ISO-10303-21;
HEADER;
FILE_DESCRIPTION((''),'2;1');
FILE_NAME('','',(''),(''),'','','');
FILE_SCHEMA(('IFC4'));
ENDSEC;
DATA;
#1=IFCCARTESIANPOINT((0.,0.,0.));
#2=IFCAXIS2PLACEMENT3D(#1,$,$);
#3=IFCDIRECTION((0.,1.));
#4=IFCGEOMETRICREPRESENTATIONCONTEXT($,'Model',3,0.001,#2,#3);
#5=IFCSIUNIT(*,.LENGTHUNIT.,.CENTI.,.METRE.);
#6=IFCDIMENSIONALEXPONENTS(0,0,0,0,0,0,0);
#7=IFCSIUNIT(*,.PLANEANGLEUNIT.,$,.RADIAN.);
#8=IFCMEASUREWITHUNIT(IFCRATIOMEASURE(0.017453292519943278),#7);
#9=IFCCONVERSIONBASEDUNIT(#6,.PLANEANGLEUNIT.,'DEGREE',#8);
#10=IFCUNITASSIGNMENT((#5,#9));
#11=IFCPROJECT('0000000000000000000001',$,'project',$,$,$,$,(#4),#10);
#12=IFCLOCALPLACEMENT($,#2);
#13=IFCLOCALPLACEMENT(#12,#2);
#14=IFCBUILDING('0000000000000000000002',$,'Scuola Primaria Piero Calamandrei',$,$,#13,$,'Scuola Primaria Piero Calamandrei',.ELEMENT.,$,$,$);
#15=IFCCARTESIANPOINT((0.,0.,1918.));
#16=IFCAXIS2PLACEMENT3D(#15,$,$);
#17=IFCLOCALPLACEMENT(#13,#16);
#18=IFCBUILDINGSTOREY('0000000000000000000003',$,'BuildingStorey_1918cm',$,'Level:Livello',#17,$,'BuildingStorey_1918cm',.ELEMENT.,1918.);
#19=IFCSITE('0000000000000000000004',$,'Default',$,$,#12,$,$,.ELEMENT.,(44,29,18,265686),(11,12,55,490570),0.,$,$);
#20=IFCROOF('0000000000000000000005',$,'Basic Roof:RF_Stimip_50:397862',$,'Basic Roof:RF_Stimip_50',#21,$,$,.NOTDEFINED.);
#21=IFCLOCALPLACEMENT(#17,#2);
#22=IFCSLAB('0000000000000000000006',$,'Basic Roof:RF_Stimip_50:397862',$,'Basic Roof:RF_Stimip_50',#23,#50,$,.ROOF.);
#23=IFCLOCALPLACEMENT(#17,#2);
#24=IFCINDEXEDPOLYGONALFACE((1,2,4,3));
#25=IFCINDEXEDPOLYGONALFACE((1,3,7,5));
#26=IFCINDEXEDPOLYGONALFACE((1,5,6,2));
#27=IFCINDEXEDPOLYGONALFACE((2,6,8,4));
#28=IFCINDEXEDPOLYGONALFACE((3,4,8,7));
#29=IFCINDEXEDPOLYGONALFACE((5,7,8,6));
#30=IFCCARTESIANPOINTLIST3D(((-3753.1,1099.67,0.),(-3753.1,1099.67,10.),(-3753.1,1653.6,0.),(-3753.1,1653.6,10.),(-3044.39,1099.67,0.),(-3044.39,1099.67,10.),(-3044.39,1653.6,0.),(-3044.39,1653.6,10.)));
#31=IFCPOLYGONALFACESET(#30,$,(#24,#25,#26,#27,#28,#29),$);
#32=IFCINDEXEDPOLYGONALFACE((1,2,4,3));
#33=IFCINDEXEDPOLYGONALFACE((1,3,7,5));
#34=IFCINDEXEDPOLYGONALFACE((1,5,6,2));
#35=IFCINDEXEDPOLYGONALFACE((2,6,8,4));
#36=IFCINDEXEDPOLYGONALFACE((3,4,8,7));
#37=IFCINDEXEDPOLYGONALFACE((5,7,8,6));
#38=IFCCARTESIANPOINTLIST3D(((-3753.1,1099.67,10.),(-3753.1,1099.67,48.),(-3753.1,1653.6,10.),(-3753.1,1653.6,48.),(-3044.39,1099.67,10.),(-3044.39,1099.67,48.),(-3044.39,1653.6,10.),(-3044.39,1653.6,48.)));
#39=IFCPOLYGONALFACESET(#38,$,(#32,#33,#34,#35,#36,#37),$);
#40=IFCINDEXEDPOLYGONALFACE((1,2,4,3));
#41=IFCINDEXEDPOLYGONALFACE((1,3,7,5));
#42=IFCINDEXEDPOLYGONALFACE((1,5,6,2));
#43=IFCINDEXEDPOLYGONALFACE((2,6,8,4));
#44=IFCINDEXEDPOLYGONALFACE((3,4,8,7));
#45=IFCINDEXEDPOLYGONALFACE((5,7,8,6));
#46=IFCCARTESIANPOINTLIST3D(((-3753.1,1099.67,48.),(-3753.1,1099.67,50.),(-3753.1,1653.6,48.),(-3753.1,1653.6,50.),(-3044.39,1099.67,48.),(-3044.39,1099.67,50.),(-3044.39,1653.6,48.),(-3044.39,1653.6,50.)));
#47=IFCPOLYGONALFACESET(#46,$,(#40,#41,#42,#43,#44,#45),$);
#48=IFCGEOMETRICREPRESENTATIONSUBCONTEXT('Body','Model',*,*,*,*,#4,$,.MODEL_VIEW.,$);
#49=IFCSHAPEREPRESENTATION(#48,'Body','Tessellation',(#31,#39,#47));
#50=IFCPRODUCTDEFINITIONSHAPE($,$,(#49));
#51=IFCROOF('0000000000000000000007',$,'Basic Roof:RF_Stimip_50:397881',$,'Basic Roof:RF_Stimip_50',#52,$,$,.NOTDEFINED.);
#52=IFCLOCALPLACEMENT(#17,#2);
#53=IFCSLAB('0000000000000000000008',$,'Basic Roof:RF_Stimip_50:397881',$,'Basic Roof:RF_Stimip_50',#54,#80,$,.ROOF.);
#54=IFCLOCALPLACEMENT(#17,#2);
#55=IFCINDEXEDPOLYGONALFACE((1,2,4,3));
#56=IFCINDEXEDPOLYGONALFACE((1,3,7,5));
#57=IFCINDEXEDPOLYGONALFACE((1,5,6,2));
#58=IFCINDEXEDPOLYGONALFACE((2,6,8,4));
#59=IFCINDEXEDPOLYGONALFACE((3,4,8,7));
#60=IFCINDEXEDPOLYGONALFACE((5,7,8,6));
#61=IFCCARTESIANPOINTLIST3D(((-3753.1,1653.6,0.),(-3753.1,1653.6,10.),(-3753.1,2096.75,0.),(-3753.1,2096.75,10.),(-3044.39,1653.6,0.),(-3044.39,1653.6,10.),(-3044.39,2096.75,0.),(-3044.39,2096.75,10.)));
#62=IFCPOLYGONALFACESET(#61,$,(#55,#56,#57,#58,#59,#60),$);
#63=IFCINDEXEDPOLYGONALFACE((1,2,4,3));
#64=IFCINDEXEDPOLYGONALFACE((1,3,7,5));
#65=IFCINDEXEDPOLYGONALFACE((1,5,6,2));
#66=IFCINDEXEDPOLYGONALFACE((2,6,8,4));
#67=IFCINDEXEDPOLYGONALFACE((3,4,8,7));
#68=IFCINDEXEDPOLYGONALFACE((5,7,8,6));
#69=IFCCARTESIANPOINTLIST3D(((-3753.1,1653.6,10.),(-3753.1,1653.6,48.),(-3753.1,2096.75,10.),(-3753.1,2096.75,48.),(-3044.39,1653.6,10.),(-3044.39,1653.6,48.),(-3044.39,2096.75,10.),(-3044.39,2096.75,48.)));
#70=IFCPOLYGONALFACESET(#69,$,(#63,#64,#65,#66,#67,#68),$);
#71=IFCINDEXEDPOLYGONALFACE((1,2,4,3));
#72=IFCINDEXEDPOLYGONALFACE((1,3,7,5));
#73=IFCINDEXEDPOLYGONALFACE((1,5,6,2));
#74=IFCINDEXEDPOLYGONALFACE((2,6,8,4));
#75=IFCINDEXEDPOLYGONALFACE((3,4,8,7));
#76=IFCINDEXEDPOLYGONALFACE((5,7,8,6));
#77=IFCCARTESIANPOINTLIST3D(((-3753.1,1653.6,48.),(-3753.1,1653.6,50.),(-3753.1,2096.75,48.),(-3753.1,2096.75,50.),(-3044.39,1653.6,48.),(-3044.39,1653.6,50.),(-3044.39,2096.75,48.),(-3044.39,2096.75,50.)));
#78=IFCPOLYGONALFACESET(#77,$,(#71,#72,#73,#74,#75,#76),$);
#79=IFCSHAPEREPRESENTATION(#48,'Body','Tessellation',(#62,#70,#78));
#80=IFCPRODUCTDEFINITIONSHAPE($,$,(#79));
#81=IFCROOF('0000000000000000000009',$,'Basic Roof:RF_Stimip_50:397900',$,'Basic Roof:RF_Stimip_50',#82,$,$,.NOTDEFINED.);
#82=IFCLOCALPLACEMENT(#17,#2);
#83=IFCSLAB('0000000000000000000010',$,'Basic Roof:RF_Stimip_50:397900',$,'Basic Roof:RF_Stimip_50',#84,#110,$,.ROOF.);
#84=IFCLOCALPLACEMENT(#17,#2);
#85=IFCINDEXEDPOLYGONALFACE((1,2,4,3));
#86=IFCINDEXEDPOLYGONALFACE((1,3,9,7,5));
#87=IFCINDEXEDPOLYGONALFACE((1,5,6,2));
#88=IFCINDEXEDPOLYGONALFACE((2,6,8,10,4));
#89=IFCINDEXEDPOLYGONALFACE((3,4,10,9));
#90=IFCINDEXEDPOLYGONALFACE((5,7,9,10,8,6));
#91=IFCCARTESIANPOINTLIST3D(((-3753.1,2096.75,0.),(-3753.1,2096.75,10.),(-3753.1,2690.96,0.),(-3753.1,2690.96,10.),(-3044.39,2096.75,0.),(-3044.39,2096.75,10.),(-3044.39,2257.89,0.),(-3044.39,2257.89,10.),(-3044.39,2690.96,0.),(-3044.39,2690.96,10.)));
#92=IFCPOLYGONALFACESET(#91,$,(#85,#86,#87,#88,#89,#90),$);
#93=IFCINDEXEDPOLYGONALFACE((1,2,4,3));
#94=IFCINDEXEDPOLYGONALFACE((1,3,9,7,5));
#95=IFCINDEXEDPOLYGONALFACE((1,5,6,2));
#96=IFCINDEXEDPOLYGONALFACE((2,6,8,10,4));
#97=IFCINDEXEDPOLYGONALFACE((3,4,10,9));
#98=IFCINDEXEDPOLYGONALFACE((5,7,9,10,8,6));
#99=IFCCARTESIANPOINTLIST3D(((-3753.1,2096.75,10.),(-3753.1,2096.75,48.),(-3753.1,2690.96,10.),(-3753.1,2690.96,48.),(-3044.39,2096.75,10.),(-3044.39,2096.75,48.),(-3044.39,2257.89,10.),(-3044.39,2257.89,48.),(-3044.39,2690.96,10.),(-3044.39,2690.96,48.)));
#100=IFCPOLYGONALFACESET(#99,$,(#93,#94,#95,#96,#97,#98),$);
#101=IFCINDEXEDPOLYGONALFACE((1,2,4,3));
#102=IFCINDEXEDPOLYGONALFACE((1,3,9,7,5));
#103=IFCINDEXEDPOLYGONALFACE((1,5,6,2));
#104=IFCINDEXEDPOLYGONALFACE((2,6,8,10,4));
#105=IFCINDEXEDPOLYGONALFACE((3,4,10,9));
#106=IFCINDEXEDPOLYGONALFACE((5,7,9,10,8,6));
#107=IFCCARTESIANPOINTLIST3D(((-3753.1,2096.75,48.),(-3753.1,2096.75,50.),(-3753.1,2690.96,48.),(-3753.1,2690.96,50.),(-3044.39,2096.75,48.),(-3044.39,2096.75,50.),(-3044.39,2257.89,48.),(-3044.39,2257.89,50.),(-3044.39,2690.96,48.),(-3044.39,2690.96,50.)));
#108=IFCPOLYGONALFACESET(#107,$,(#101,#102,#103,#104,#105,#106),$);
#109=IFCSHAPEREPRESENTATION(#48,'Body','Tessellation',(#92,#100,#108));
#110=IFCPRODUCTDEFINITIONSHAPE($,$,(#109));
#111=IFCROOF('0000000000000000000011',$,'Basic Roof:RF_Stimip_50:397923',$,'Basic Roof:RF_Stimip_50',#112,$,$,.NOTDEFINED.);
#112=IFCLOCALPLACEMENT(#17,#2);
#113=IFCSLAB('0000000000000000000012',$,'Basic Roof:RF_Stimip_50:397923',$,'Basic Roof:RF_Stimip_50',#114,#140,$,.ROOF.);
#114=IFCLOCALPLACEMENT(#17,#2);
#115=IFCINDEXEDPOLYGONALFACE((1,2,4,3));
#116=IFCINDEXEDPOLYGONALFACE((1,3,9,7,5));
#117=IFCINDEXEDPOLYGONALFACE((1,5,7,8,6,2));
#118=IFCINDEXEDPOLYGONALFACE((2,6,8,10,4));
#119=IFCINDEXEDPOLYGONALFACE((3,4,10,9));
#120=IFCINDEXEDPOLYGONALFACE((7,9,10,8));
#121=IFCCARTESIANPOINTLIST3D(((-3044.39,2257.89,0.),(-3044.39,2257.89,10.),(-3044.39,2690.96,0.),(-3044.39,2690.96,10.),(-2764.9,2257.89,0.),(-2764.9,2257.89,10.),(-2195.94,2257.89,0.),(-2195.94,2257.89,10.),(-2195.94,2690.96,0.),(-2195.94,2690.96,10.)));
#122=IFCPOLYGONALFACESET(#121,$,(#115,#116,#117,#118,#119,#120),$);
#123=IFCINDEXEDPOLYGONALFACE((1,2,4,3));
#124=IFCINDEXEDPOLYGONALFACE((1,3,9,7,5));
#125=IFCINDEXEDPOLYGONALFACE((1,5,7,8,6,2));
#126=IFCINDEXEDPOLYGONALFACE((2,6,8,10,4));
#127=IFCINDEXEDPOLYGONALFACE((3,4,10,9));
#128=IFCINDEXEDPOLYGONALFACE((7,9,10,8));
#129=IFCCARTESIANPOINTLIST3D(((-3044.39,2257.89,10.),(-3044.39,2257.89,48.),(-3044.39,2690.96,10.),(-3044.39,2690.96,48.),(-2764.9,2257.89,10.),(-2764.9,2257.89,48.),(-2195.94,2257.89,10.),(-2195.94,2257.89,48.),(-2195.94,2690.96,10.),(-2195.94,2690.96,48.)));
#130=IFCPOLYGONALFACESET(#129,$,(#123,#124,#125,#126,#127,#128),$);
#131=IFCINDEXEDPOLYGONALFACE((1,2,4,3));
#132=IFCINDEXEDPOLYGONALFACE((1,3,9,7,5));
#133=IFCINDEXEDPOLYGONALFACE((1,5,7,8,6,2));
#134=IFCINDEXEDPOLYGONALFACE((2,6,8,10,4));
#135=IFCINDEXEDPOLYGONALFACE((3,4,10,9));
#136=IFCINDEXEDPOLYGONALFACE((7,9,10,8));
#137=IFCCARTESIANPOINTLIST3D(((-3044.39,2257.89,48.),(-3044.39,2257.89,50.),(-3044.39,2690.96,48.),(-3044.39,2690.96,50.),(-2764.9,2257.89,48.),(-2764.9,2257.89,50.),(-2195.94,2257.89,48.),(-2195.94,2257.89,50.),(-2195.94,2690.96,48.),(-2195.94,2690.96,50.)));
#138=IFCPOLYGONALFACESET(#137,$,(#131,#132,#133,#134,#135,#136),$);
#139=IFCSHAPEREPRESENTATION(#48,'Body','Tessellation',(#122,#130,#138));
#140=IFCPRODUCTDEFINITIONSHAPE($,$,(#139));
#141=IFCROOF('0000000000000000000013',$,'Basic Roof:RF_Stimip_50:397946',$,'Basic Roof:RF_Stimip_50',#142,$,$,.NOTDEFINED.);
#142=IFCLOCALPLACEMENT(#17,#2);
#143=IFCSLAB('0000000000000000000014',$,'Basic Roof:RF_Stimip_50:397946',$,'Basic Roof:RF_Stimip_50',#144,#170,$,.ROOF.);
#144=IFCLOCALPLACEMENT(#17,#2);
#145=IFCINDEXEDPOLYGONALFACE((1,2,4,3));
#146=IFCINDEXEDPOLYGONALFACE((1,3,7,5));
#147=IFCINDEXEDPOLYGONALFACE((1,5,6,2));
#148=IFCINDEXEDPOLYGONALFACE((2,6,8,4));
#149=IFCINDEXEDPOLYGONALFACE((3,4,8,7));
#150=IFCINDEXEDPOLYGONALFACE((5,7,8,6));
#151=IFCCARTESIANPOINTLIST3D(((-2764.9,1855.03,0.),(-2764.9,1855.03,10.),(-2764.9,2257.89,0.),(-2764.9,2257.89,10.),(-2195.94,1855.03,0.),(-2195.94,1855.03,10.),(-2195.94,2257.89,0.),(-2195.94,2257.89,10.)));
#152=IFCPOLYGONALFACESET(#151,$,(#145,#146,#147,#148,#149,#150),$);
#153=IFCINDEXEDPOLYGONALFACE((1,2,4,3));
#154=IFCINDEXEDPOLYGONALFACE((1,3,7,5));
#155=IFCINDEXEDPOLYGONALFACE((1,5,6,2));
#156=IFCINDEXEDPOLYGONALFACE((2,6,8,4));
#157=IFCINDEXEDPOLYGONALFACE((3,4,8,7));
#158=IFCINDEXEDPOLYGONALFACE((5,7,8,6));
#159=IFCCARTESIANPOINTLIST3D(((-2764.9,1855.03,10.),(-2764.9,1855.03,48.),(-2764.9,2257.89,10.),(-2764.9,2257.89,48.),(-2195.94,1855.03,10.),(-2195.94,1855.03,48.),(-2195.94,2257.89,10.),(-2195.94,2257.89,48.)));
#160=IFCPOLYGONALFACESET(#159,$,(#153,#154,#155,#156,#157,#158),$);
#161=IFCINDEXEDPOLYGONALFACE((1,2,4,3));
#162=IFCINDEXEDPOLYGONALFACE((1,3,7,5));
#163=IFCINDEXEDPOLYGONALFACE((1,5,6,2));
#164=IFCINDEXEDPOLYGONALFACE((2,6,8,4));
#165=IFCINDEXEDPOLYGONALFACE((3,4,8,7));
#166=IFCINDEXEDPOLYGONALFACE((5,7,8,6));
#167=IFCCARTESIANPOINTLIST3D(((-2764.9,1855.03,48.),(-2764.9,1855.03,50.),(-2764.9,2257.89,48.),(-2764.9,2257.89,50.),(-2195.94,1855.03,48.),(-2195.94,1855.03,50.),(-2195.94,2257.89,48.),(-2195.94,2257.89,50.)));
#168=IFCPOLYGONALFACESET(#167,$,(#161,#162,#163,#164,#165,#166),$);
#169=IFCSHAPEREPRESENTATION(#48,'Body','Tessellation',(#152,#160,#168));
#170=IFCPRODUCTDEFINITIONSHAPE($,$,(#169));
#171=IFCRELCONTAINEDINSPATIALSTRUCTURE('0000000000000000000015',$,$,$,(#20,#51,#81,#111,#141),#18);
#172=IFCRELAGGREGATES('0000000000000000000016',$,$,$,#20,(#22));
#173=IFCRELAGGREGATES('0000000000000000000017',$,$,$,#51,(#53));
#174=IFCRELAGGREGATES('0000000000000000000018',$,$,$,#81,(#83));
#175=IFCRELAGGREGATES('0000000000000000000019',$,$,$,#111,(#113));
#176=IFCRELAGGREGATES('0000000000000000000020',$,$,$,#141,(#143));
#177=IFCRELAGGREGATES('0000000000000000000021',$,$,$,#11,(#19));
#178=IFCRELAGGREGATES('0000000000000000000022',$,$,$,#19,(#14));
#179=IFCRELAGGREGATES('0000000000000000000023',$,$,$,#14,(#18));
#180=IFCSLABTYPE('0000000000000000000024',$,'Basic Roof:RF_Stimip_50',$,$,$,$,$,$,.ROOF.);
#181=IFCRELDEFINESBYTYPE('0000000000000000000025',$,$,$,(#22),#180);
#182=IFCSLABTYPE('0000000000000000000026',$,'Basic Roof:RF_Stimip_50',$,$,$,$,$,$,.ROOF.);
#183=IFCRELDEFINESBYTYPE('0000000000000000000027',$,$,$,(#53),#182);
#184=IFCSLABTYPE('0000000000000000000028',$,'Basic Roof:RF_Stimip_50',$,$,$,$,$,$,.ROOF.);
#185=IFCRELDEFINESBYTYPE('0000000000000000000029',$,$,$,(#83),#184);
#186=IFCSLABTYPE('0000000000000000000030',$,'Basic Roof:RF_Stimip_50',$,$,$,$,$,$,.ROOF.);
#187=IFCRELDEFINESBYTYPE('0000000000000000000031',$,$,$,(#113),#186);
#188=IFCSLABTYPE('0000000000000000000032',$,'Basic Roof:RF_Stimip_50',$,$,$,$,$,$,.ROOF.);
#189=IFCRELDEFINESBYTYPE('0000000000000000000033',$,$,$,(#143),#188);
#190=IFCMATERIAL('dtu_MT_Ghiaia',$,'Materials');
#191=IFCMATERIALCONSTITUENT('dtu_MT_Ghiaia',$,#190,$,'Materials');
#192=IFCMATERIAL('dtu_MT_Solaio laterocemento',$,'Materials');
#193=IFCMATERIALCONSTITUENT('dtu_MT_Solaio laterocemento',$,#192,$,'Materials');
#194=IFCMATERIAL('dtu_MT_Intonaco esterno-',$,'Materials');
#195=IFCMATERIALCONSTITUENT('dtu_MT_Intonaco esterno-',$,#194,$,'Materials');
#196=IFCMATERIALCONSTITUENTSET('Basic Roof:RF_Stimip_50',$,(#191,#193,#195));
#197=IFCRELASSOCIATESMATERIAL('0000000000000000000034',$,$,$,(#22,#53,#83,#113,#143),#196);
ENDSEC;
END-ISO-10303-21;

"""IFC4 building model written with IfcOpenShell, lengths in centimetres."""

from ifc_helpers import new_model, entity, si_unit, converted_unit, direction, frame, origin, place, context, subcontext, project, spatial, indexed_curve, outline, extrude, material, constituent, constituent_set, type_object, element, aggregate, save


model = new_model("IFC4")

# Units and contexts
model_context = context("Model", 3, precision=0.001, world=origin(), true_north=direction((0.0, 1.0)))
body_context = subcontext(model_context, "Body", "Model", "MODEL_VIEW")
ifc_project = project(units=[si_unit("LENGTHUNIT", "METRE", prefix="CENTI"), converted_unit("PLANEANGLEUNIT", "DEGREE", entity("IfcRatioMeasure", 0.017453292519943278), si_unit("PLANEANGLEUNIT", "RADIAN"), dimensions=[0, 0, 0, 0, 0, 0, 0])], contexts=[model_context])

# Site, building, storey
site_placement = place(None, origin())
site = spatial("IfcSite", under=ifc_project, at=site_placement, Name="Default", CompositionType="ELEMENT", RefLatitude=(44, 29, 18, 265686), RefLongitude=(11, 12, 55, 490570), RefElevation=0.0)
building_placement = place(site_placement, origin())
building = spatial("IfcBuilding", under=site, at=building_placement, Name="Scuola Primaria Piero Calamandrei", LongName="Scuola Primaria Piero Calamandrei", CompositionType="ELEMENT")
storey_placement = place(building_placement, frame((0.0, 0.0, 1918.0)))
storey = spatial("IfcBuildingStorey", under=building, at=storey_placement, Name="BuildingStorey_1918cm", ObjectType="Level:Livello", LongName="BuildingStorey_1918cm", CompositionType="ELEMENT", Elevation=1918.0)

# Roofs, slabs
ifc_material_1 = material(Name="dtu_MT_Ghiaia", Category="Materials")
ifc_constituent_1 = constituent(ifc_material_1, Name="dtu_MT_Ghiaia", Category="Materials")
ifc_material_2 = material(Name="dtu_MT_Solaio laterocemento", Category="Materials")
ifc_constituent_2 = constituent(ifc_material_2, Name="dtu_MT_Solaio laterocemento", Category="Materials")
ifc_material_3 = material(Name="dtu_MT_Intonaco esterno-", Category="Materials")
ifc_constituent_3 = constituent(ifc_material_3, Name="dtu_MT_Intonaco esterno-", Category="Materials")
ifc_constituent_set = constituent_set(constituents=[ifc_constituent_1, ifc_constituent_2, ifc_constituent_3], Name="Basic Roof:RF_Stimip_50")
roof_1_placement = place(storey_placement, frame((-3753.1, 1099.67, 0.0)))
roof_1 = element("IfcRoof", 1, at=roof_1_placement, inside=storey, Name="Basic Roof:RF_Stimip_50:397862", ObjectType="Basic Roof:RF_Stimip_50", PredefinedType="NOTDEFINED")
slab_type_1 = type_object("IfcSlabType", Name="Basic Roof:RF_Stimip_50", PredefinedType="ROOF")
slab_1_placement = place(roof_1_placement, origin())
slab_1 = element("IfcSlab", 2, at=slab_1_placement, type_object=slab_type_1, material=ifc_constituent_set, Name="Basic Roof:RF_Stimip_50:397862", ObjectType="Basic Roof:RF_Stimip_50", PredefinedType="ROOF", context=body_context, shape_type="SweptSolid", body=[
    extrude(outline(indexed_curve([(-354.35, 276.96), (-354.35, -276.96), (354.35, -276.96), (354.35, 276.96), (-354.35, 276.96)], self_intersect=False)), frame((354.35, 276.96, 0.0)), (0.0, 0.0, 1.0), 10.0),
    extrude(outline(indexed_curve([(-354.35, 276.96), (-354.35, -276.96), (354.35, -276.96), (354.35, 276.96), (-354.35, 276.96)], self_intersect=False)), frame((354.35, 276.96, 10.0)), (0.0, 0.0, 1.0), 38.0),
    extrude(outline(indexed_curve([(-354.35, 276.96), (-354.35, -276.96), (354.35, -276.96), (354.35, 276.96), (-354.35, 276.96)], self_intersect=False)), frame((354.35, 276.96, 48.0)), (0.0, 0.0, 1.0), 2.0),
])
aggregate(roof_1, [slab_1])
roof_2_placement = place(storey_placement, frame((-3753.1, 1653.6, 0.0)))
roof_2 = element("IfcRoof", 3, at=roof_2_placement, inside=storey, Name="Basic Roof:RF_Stimip_50:397881", ObjectType="Basic Roof:RF_Stimip_50", PredefinedType="NOTDEFINED")
slab_type_2 = type_object("IfcSlabType", Name="Basic Roof:RF_Stimip_50", PredefinedType="ROOF")
slab_2_placement = place(roof_2_placement, origin())
slab_2 = element("IfcSlab", 4, at=slab_2_placement, type_object=slab_type_2, material=ifc_constituent_set, Name="Basic Roof:RF_Stimip_50:397881", ObjectType="Basic Roof:RF_Stimip_50", PredefinedType="ROOF", context=body_context, shape_type="SweptSolid", body=[
    extrude(outline(indexed_curve([(-354.35, -221.57), (354.35, -221.57), (354.35, 221.57), (-354.35, 221.57), (-354.35, -221.57)], self_intersect=False)), frame((354.35, 221.57, 0.0)), (0.0, 0.0, 1.0), 10.0),
    extrude(outline(indexed_curve([(-354.35, -221.57), (354.35, -221.57), (354.35, 221.57), (-354.35, 221.57), (-354.35, -221.57)], self_intersect=False)), frame((354.35, 221.57, 10.0)), (0.0, 0.0, 1.0), 38.0),
    extrude(outline(indexed_curve([(-354.35, -221.57), (354.35, -221.57), (354.35, 221.57), (-354.35, 221.57), (-354.35, -221.57)], self_intersect=False)), frame((354.35, 221.57, 48.0)), (0.0, 0.0, 1.0), 2.0),
])
aggregate(roof_2, [slab_2])
roof_3_placement = place(storey_placement, frame((-3753.1, 2096.75, 0.0)))
roof_3 = element("IfcRoof", 5, at=roof_3_placement, inside=storey, Name="Basic Roof:RF_Stimip_50:397900", ObjectType="Basic Roof:RF_Stimip_50", PredefinedType="NOTDEFINED")
slab_type_3 = type_object("IfcSlabType", Name="Basic Roof:RF_Stimip_50", PredefinedType="ROOF")
slab_3_placement = place(roof_3_placement, origin())
slab_3 = element("IfcSlab", 6, at=slab_3_placement, type_object=slab_type_3, material=ifc_constituent_set, Name="Basic Roof:RF_Stimip_50:397900", ObjectType="Basic Roof:RF_Stimip_50", PredefinedType="ROOF", context=body_context, shape_type="SweptSolid", body=[
    extrude(outline(indexed_curve([(-354.35, -297.11), (354.35, -297.11), (354.35, -135.96), (354.35, 297.11), (-354.35, 297.11), (-354.35, -297.11)], self_intersect=False)), frame((354.35, 297.11, 0.0)), (0.0, 0.0, 1.0), 10.0),
    extrude(outline(indexed_curve([(-354.35, -297.11), (354.35, -297.11), (354.35, -135.96), (354.35, 297.11), (-354.35, 297.11), (-354.35, -297.11)], self_intersect=False)), frame((354.35, 297.11, 10.0)), (0.0, 0.0, 1.0), 38.0),
    extrude(outline(indexed_curve([(-354.35, -297.11), (354.35, -297.11), (354.35, -135.96), (354.35, 297.11), (-354.35, 297.11), (-354.35, -297.11)], self_intersect=False)), frame((354.35, 297.11, 48.0)), (0.0, 0.0, 1.0), 2.0),
])
aggregate(roof_3, [slab_3])
roof_4_placement = place(storey_placement, frame((-3044.39, 2257.89, 0.0)))
roof_4 = element("IfcRoof", 7, at=roof_4_placement, inside=storey, Name="Basic Roof:RF_Stimip_50:397923", ObjectType="Basic Roof:RF_Stimip_50", PredefinedType="NOTDEFINED")
slab_type_4 = type_object("IfcSlabType", Name="Basic Roof:RF_Stimip_50", PredefinedType="ROOF")
slab_4_placement = place(roof_4_placement, origin())
slab_4 = element("IfcSlab", 8, at=slab_4_placement, type_object=slab_type_4, material=ifc_constituent_set, Name="Basic Roof:RF_Stimip_50:397923", ObjectType="Basic Roof:RF_Stimip_50", PredefinedType="ROOF", context=body_context, shape_type="SweptSolid", body=[
    extrude(outline(indexed_curve([(-144.74, -216.54), (424.23, -216.54), (424.23, 216.54), (-424.23, 216.54), (-424.23, -216.54), (-144.74, -216.54)], self_intersect=False)), frame((424.23, 216.54, 0.0)), (0.0, 0.0, 1.0), 10.0),
    extrude(outline(indexed_curve([(-144.74, -216.54), (424.23, -216.54), (424.23, 216.54), (-424.23, 216.54), (-424.23, -216.54), (-144.74, -216.54)], self_intersect=False)), frame((424.23, 216.54, 10.0)), (0.0, 0.0, 1.0), 38.0),
    extrude(outline(indexed_curve([(-144.74, -216.54), (424.23, -216.54), (424.23, 216.54), (-424.23, 216.54), (-424.23, -216.54), (-144.74, -216.54)], self_intersect=False)), frame((424.23, 216.54, 48.0)), (0.0, 0.0, 1.0), 2.0),
])
aggregate(roof_4, [slab_4])
roof_5_placement = place(storey_placement, frame((-2764.9, 1855.03, 0.0)))
roof_5 = element("IfcRoof", 9, at=roof_5_placement, inside=storey, Name="Basic Roof:RF_Stimip_50:397946", ObjectType="Basic Roof:RF_Stimip_50", PredefinedType="NOTDEFINED")
slab_type_5 = type_object("IfcSlabType", Name="Basic Roof:RF_Stimip_50", PredefinedType="ROOF")
slab_5_placement = place(roof_5_placement, origin())
slab_5 = element("IfcSlab", 10, at=slab_5_placement, type_object=slab_type_5, material=ifc_constituent_set, Name="Basic Roof:RF_Stimip_50:397946", ObjectType="Basic Roof:RF_Stimip_50", PredefinedType="ROOF", context=body_context, shape_type="SweptSolid", body=[
    extrude(outline(indexed_curve([(284.48, -201.43), (284.48, 201.43), (-284.48, 201.43), (-284.48, -201.43), (284.48, -201.43)], self_intersect=False)), frame((284.48, 201.43, 0.0)), (0.0, 0.0, 1.0), 10.0),
    extrude(outline(indexed_curve([(284.48, -201.43), (284.48, 201.43), (-284.48, 201.43), (-284.48, -201.43), (284.48, -201.43)], self_intersect=False)), frame((284.48, 201.43, 10.0)), (0.0, 0.0, 1.0), 38.0),
    extrude(outline(indexed_curve([(284.48, -201.43), (284.48, 201.43), (-284.48, 201.43), (-284.48, -201.43), (284.48, -201.43)], self_intersect=False)), frame((284.48, 201.43, 48.0)), (0.0, 0.0, 1.0), 2.0),
])
aggregate(roof_5, [slab_5])

save(model, "model.ifc")
